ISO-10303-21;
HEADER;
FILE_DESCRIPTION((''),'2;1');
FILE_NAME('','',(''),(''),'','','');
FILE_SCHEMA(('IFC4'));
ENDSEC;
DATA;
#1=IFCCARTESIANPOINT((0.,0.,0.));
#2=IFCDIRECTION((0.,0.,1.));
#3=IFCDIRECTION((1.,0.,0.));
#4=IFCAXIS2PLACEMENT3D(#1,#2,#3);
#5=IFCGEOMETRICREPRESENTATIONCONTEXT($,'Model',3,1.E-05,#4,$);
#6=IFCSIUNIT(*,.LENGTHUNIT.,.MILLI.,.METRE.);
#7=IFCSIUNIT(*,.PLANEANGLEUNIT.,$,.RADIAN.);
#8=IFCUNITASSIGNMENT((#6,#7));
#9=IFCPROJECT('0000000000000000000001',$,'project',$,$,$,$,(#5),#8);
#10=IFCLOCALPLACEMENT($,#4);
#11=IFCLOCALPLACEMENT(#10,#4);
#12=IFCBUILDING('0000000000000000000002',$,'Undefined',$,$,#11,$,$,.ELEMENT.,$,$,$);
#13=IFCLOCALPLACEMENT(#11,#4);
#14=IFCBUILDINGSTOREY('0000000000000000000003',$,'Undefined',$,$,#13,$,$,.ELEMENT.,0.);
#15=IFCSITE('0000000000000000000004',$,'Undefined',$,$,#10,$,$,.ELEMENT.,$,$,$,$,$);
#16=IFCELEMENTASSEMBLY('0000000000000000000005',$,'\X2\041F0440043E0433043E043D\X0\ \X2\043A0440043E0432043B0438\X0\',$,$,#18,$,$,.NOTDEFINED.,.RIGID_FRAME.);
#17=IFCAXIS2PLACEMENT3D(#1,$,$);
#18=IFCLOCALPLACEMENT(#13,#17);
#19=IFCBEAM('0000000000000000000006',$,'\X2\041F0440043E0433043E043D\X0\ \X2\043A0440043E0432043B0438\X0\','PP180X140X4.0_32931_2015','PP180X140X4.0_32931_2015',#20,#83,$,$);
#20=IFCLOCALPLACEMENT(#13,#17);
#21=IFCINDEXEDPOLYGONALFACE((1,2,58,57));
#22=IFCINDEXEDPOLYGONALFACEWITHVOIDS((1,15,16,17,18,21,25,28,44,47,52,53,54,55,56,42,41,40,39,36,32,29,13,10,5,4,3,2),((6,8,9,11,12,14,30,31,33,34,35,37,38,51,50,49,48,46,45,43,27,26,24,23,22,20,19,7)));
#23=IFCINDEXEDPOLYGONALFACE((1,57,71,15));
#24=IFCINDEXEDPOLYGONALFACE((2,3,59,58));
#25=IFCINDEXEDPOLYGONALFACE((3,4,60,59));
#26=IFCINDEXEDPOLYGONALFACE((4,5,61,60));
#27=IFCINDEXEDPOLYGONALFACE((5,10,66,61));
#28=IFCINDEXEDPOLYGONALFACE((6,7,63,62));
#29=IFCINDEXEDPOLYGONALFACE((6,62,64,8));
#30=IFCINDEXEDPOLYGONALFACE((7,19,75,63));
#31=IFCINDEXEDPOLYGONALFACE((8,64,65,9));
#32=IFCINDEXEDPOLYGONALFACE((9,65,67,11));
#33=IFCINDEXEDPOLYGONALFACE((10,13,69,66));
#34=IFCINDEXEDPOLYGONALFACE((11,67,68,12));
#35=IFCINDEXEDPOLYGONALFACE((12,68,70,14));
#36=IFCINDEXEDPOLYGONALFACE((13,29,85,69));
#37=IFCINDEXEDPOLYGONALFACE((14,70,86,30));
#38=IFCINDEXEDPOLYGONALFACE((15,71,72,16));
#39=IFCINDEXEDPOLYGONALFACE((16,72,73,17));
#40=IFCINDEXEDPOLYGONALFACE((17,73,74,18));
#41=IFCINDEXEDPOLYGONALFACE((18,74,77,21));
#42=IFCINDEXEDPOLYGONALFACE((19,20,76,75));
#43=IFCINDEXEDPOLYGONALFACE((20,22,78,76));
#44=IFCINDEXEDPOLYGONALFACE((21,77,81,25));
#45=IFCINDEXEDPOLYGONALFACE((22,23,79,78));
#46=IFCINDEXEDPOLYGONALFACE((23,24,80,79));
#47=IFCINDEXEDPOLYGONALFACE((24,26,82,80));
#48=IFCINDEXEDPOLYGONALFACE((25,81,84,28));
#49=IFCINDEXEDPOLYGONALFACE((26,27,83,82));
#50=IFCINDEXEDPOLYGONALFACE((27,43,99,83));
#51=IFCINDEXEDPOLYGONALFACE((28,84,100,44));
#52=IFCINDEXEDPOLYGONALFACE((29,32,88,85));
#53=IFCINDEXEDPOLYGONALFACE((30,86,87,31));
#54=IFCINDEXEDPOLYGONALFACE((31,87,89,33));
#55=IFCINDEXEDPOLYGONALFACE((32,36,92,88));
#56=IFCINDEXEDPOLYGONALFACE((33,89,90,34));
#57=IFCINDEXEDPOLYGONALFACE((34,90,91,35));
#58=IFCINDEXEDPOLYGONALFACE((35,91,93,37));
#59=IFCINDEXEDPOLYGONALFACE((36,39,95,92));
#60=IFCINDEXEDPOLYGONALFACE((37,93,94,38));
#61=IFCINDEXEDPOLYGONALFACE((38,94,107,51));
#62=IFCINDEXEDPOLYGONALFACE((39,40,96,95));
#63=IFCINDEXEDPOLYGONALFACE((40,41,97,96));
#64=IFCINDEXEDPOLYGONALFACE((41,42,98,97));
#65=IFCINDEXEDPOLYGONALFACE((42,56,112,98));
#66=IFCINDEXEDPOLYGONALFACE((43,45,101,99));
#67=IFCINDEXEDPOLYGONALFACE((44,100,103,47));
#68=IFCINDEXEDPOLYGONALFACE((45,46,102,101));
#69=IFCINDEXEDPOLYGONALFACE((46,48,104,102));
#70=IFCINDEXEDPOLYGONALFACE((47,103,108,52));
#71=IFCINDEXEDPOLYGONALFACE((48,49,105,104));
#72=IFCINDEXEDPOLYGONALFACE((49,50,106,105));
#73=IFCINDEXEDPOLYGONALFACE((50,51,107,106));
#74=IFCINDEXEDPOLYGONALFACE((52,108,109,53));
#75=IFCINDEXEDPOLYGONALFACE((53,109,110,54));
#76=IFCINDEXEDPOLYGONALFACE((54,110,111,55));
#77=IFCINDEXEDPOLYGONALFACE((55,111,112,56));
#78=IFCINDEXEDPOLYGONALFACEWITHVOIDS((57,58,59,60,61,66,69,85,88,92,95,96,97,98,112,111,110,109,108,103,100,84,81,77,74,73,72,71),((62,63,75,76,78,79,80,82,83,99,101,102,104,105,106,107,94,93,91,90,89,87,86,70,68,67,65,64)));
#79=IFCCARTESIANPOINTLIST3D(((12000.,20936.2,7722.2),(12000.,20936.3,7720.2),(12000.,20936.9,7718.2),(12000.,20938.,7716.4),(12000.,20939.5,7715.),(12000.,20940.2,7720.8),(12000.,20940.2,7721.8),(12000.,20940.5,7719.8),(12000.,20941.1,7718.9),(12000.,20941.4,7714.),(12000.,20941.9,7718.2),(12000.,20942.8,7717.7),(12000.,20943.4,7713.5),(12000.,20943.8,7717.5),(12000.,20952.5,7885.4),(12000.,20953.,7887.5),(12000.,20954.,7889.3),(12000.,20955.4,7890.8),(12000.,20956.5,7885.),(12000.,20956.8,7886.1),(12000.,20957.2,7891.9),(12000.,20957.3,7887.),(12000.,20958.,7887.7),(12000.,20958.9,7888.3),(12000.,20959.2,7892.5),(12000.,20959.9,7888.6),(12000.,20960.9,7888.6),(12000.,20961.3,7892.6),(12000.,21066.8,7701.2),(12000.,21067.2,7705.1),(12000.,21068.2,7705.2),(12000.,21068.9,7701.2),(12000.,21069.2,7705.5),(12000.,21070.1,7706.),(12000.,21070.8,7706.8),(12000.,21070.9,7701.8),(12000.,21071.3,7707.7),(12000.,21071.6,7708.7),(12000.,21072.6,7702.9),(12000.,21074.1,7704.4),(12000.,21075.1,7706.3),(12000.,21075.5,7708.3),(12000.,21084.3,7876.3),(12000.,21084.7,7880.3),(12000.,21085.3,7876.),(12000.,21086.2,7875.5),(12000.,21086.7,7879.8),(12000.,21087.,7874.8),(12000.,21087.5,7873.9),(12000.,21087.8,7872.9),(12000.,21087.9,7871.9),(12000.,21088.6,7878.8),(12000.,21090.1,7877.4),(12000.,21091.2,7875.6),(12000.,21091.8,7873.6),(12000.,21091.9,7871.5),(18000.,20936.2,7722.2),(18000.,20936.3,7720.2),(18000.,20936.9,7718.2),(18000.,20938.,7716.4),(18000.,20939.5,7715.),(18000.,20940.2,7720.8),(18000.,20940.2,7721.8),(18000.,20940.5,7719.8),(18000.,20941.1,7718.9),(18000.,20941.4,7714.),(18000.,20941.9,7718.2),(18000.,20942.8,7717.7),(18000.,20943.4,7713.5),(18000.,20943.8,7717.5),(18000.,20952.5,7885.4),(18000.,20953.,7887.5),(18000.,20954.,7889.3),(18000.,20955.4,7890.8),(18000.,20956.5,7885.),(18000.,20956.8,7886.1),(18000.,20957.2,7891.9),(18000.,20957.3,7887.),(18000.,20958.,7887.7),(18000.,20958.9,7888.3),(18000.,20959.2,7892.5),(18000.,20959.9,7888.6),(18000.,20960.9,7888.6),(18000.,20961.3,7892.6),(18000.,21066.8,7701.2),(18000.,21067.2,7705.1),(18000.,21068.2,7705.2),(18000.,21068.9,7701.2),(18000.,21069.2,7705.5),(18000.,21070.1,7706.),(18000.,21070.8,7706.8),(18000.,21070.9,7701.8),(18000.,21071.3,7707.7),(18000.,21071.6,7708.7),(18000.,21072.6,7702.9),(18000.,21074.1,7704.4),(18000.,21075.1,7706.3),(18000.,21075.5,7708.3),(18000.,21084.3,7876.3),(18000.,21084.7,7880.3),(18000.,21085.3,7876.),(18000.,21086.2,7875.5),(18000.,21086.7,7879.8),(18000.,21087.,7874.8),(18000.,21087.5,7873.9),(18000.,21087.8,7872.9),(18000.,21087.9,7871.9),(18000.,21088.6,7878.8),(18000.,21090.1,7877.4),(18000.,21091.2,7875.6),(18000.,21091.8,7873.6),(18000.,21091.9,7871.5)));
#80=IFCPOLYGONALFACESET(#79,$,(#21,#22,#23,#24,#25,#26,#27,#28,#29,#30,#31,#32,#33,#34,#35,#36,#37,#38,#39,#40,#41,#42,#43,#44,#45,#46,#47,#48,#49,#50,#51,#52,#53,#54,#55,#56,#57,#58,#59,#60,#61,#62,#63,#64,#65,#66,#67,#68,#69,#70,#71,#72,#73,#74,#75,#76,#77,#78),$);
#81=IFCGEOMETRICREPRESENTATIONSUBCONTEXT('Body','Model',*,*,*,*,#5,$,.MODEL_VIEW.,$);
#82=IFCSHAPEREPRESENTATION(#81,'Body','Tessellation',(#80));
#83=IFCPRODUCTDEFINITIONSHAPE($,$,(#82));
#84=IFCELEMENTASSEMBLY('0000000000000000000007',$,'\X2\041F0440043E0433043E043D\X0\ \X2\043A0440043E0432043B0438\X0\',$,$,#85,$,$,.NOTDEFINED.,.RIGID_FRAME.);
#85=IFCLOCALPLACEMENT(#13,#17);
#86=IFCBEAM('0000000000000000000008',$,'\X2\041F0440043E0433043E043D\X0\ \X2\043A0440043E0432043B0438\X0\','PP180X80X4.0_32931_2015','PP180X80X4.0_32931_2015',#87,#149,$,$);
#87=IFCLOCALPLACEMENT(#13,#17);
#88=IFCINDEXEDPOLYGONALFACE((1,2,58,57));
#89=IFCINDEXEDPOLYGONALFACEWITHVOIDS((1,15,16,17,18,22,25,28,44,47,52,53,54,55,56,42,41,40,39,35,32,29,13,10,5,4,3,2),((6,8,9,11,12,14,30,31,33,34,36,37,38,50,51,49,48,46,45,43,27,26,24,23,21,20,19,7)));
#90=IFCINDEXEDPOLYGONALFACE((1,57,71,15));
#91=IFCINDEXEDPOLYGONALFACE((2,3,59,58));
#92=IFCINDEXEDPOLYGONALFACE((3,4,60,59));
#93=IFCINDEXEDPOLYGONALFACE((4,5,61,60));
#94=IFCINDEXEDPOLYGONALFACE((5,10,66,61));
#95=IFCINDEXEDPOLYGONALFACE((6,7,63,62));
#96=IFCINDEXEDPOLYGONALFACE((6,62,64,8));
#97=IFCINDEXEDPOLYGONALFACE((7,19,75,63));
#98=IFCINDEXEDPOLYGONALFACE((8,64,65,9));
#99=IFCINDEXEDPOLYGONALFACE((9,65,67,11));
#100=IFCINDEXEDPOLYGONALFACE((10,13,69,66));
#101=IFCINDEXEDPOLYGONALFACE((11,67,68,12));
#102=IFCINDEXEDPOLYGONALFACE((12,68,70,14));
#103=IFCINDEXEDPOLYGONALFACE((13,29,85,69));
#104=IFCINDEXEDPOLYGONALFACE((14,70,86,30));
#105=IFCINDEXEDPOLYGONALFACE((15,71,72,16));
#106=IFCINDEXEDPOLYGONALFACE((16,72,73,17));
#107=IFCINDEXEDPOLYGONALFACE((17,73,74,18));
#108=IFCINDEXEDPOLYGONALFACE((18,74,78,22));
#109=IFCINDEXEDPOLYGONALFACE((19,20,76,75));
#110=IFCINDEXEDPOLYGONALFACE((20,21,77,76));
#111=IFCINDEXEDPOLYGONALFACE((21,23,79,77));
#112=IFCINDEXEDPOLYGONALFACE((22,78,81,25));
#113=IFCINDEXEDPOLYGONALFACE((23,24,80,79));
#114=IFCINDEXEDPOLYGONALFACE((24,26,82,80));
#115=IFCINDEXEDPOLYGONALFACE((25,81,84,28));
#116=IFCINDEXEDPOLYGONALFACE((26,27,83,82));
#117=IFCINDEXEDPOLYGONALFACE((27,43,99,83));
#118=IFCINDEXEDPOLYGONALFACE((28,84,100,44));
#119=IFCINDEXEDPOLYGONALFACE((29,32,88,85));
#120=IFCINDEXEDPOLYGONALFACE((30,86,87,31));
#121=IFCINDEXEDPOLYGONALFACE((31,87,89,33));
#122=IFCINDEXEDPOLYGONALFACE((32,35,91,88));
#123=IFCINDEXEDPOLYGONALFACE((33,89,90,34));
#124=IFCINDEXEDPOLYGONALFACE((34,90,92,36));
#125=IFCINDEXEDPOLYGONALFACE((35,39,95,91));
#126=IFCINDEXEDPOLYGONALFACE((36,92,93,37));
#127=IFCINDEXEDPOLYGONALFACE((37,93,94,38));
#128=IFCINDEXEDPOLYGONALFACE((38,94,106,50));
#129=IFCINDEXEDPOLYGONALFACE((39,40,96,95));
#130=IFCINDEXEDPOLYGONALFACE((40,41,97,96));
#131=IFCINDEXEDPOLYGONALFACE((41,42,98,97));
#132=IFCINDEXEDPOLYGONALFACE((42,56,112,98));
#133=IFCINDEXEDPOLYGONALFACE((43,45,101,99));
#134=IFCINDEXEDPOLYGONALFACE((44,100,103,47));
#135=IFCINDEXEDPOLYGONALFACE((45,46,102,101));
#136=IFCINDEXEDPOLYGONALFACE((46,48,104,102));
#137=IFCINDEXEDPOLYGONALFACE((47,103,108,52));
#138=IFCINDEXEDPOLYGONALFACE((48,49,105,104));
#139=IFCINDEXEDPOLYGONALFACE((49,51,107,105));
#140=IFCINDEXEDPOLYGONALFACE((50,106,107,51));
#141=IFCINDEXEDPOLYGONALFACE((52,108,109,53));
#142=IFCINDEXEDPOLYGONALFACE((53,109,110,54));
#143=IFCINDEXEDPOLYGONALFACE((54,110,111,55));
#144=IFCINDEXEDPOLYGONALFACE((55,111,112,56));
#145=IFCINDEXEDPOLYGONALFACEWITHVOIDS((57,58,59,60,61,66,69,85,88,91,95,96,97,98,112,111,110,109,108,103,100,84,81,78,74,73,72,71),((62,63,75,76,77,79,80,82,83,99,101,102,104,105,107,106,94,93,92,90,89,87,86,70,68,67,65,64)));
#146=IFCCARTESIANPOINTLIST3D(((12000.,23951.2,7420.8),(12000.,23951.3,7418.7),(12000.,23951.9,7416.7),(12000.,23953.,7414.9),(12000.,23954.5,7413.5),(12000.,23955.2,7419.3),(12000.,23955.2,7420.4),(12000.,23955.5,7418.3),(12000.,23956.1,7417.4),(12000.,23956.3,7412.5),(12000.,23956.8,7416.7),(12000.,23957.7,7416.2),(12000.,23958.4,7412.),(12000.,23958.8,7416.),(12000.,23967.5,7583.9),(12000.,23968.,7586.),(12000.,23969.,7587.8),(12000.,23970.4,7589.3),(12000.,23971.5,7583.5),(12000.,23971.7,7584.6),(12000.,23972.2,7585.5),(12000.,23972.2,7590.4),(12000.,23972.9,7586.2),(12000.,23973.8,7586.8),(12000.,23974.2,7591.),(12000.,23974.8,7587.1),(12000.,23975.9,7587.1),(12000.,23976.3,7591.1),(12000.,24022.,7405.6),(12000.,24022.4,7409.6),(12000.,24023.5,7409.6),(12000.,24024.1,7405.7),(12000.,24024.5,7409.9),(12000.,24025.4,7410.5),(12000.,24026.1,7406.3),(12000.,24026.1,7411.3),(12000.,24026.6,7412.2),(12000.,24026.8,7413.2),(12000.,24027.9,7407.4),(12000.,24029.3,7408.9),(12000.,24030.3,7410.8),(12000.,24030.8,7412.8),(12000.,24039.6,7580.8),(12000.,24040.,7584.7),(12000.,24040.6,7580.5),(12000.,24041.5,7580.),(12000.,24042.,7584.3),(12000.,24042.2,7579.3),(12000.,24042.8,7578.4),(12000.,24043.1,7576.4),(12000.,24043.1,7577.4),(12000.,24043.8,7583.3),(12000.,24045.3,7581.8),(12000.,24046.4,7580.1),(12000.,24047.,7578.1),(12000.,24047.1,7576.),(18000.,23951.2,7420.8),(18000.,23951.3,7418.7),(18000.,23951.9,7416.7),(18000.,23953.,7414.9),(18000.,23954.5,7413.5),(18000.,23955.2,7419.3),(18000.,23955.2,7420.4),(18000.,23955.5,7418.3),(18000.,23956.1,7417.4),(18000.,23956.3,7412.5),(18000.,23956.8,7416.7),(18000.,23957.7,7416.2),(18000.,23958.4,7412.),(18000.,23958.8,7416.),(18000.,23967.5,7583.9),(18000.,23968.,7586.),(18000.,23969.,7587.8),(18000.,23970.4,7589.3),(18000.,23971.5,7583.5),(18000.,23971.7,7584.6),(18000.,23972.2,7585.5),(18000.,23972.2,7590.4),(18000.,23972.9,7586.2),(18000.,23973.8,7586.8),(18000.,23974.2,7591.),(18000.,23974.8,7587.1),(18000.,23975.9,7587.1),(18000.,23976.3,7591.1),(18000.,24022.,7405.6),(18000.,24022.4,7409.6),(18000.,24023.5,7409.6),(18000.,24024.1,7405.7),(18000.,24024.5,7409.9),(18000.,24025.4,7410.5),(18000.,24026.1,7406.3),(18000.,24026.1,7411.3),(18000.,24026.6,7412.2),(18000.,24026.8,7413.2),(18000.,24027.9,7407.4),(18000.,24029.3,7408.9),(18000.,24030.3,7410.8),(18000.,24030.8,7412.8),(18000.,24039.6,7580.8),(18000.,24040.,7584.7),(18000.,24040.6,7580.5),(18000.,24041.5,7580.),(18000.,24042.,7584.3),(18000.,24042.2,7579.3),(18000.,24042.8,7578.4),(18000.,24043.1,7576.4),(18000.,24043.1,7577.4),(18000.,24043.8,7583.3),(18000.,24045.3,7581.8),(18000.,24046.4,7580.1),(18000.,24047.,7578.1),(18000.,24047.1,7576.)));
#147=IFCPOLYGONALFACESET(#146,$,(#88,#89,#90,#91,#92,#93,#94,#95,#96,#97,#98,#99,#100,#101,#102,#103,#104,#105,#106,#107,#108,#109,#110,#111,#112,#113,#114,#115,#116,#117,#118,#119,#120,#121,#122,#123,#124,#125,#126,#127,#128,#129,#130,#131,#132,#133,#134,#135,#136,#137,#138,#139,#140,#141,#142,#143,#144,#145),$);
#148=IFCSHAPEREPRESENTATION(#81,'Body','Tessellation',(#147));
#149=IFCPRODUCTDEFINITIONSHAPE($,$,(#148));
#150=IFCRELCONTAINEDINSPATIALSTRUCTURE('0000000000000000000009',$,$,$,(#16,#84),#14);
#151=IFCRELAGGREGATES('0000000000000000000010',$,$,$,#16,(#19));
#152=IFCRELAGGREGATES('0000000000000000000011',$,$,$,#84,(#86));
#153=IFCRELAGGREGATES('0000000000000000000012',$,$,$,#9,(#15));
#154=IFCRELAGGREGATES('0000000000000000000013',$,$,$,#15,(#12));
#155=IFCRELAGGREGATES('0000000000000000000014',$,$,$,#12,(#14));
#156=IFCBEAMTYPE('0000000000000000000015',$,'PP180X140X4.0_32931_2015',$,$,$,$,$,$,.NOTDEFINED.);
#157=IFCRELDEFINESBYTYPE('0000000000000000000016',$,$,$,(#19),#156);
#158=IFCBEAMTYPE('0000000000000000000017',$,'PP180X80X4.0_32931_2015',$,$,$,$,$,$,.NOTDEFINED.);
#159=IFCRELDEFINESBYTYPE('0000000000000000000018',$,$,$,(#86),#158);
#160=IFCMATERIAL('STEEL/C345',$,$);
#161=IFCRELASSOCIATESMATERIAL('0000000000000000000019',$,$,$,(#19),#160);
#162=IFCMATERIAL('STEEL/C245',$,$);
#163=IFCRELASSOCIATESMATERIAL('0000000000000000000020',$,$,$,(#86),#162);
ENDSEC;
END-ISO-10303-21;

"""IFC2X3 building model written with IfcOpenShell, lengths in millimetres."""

from ifc_helpers import new_model, si_unit, frame, origin_with_axes, origin_2d_with_axis, place, context, subcontext, project, spatial, hollow_rectangle, extrude, material, type_object, element, aggregate, save


model = new_model("IFC2X3")

# Units and contexts
model_context = context("Model", 3, precision=1e-05, world=origin_with_axes())
body_context = subcontext(model_context, "Body", "Model", "MODEL_VIEW")
ifc_project = project(units=[si_unit("LENGTHUNIT", "METRE", prefix="MILLI"), si_unit("PLANEANGLEUNIT", "RADIAN")], contexts=[model_context])

# Site, building, storey
site_placement = place(None, origin_with_axes())
site = spatial("IfcSite", under=ifc_project, at=site_placement, Name="Undefined", CompositionType="ELEMENT")
building_placement = place(site_placement, origin_with_axes())
building = spatial("IfcBuilding", under=site, at=building_placement, Name="Undefined", CompositionType="ELEMENT")
storey_placement = place(building_placement, origin_with_axes())
storey = spatial("IfcBuildingStorey", under=building, at=storey_placement, Name="Undefined", CompositionType="ELEMENT", Elevation=0.0)

# Shared definitions
ifc_material_1 = material(Name="STEEL/C245")

# Element assembly, beam
assembly_1_placement = place(storey_placement, origin_with_axes())
assembly_1 = element("IfcElementAssembly", 1, at=assembly_1_placement, inside=storey, Name="Прогон кровли", AssemblyPlace="NOTDEFINED", PredefinedType="RIGID_FRAME")
ifc_material_2 = material(Name="STEEL/C345")
beam_type_1 = type_object("IfcBeamType", Name="PP180X140X4.0_32931_2015", PredefinedType="NOTDEFINED")
beam_1_placement = place(assembly_1_placement, frame((12000.0, 21014.0, 7796.9), z_axis=(0.0, 0.099504, 0.995037), x_axis=(1.0, 0.0, 0.0)))
beam_1 = element("IfcBeam", 2, at=beam_1_placement, type_object=beam_type_1, material=ifc_material_2, Name="Прогон кровли", Description="PP180X140X4.0_32931_2015", ObjectType="PP180X140X4.0_32931_2015", context=body_context, shape_type="SweptSolid", body=[
    extrude(hollow_rectangle(XDim=140.0, YDim=180.0, WallThickness=4.0, InnerFilletRadius=4.0, OuterFilletRadius=8.0, at=origin_2d_with_axis()), frame((6000.0, 0.0, 0.0), z_axis=(-1.0, 0.0, 0.0), x_axis=(0.0, -1.0, 0.0)), (0.0, 0.0, 1.0), 6000.0),
])
aggregate(assembly_1, [beam_1])

# Element assembly, beam
assembly_2_placement = place(storey_placement, origin_with_axes())
assembly_2 = element("IfcElementAssembly", 3, at=assembly_2_placement, inside=storey, Name="Прогон кровли", AssemblyPlace="NOTDEFINED", PredefinedType="RIGID_FRAME")
beam_type_2 = type_object("IfcBeamType", Name="PP180X80X4.0_32931_2015", PredefinedType="NOTDEFINED")
beam_2_placement = place(assembly_2_placement, frame((12000.0, 23999.2, 7498.4), z_axis=(0.0, 0.099504, 0.995037), x_axis=(1.0, 0.0, 0.0)))
beam_2 = element("IfcBeam", 4, at=beam_2_placement, type_object=beam_type_2, material=ifc_material_1, Name="Прогон кровли", Description="PP180X80X4.0_32931_2015", ObjectType="PP180X80X4.0_32931_2015", context=body_context, shape_type="SweptSolid", body=[
    extrude(hollow_rectangle(XDim=80.0, YDim=180.0, WallThickness=4.0, InnerFilletRadius=4.0, OuterFilletRadius=8.0, at=origin_2d_with_axis()), frame((6000.0, 0.0, 0.0), z_axis=(-1.0, 0.0, 0.0), x_axis=(0.0, -1.0, 0.0)), (0.0, 0.0, 1.0), 6000.0),
])
aggregate(assembly_2, [beam_2])

save(model, "model.ifc")
